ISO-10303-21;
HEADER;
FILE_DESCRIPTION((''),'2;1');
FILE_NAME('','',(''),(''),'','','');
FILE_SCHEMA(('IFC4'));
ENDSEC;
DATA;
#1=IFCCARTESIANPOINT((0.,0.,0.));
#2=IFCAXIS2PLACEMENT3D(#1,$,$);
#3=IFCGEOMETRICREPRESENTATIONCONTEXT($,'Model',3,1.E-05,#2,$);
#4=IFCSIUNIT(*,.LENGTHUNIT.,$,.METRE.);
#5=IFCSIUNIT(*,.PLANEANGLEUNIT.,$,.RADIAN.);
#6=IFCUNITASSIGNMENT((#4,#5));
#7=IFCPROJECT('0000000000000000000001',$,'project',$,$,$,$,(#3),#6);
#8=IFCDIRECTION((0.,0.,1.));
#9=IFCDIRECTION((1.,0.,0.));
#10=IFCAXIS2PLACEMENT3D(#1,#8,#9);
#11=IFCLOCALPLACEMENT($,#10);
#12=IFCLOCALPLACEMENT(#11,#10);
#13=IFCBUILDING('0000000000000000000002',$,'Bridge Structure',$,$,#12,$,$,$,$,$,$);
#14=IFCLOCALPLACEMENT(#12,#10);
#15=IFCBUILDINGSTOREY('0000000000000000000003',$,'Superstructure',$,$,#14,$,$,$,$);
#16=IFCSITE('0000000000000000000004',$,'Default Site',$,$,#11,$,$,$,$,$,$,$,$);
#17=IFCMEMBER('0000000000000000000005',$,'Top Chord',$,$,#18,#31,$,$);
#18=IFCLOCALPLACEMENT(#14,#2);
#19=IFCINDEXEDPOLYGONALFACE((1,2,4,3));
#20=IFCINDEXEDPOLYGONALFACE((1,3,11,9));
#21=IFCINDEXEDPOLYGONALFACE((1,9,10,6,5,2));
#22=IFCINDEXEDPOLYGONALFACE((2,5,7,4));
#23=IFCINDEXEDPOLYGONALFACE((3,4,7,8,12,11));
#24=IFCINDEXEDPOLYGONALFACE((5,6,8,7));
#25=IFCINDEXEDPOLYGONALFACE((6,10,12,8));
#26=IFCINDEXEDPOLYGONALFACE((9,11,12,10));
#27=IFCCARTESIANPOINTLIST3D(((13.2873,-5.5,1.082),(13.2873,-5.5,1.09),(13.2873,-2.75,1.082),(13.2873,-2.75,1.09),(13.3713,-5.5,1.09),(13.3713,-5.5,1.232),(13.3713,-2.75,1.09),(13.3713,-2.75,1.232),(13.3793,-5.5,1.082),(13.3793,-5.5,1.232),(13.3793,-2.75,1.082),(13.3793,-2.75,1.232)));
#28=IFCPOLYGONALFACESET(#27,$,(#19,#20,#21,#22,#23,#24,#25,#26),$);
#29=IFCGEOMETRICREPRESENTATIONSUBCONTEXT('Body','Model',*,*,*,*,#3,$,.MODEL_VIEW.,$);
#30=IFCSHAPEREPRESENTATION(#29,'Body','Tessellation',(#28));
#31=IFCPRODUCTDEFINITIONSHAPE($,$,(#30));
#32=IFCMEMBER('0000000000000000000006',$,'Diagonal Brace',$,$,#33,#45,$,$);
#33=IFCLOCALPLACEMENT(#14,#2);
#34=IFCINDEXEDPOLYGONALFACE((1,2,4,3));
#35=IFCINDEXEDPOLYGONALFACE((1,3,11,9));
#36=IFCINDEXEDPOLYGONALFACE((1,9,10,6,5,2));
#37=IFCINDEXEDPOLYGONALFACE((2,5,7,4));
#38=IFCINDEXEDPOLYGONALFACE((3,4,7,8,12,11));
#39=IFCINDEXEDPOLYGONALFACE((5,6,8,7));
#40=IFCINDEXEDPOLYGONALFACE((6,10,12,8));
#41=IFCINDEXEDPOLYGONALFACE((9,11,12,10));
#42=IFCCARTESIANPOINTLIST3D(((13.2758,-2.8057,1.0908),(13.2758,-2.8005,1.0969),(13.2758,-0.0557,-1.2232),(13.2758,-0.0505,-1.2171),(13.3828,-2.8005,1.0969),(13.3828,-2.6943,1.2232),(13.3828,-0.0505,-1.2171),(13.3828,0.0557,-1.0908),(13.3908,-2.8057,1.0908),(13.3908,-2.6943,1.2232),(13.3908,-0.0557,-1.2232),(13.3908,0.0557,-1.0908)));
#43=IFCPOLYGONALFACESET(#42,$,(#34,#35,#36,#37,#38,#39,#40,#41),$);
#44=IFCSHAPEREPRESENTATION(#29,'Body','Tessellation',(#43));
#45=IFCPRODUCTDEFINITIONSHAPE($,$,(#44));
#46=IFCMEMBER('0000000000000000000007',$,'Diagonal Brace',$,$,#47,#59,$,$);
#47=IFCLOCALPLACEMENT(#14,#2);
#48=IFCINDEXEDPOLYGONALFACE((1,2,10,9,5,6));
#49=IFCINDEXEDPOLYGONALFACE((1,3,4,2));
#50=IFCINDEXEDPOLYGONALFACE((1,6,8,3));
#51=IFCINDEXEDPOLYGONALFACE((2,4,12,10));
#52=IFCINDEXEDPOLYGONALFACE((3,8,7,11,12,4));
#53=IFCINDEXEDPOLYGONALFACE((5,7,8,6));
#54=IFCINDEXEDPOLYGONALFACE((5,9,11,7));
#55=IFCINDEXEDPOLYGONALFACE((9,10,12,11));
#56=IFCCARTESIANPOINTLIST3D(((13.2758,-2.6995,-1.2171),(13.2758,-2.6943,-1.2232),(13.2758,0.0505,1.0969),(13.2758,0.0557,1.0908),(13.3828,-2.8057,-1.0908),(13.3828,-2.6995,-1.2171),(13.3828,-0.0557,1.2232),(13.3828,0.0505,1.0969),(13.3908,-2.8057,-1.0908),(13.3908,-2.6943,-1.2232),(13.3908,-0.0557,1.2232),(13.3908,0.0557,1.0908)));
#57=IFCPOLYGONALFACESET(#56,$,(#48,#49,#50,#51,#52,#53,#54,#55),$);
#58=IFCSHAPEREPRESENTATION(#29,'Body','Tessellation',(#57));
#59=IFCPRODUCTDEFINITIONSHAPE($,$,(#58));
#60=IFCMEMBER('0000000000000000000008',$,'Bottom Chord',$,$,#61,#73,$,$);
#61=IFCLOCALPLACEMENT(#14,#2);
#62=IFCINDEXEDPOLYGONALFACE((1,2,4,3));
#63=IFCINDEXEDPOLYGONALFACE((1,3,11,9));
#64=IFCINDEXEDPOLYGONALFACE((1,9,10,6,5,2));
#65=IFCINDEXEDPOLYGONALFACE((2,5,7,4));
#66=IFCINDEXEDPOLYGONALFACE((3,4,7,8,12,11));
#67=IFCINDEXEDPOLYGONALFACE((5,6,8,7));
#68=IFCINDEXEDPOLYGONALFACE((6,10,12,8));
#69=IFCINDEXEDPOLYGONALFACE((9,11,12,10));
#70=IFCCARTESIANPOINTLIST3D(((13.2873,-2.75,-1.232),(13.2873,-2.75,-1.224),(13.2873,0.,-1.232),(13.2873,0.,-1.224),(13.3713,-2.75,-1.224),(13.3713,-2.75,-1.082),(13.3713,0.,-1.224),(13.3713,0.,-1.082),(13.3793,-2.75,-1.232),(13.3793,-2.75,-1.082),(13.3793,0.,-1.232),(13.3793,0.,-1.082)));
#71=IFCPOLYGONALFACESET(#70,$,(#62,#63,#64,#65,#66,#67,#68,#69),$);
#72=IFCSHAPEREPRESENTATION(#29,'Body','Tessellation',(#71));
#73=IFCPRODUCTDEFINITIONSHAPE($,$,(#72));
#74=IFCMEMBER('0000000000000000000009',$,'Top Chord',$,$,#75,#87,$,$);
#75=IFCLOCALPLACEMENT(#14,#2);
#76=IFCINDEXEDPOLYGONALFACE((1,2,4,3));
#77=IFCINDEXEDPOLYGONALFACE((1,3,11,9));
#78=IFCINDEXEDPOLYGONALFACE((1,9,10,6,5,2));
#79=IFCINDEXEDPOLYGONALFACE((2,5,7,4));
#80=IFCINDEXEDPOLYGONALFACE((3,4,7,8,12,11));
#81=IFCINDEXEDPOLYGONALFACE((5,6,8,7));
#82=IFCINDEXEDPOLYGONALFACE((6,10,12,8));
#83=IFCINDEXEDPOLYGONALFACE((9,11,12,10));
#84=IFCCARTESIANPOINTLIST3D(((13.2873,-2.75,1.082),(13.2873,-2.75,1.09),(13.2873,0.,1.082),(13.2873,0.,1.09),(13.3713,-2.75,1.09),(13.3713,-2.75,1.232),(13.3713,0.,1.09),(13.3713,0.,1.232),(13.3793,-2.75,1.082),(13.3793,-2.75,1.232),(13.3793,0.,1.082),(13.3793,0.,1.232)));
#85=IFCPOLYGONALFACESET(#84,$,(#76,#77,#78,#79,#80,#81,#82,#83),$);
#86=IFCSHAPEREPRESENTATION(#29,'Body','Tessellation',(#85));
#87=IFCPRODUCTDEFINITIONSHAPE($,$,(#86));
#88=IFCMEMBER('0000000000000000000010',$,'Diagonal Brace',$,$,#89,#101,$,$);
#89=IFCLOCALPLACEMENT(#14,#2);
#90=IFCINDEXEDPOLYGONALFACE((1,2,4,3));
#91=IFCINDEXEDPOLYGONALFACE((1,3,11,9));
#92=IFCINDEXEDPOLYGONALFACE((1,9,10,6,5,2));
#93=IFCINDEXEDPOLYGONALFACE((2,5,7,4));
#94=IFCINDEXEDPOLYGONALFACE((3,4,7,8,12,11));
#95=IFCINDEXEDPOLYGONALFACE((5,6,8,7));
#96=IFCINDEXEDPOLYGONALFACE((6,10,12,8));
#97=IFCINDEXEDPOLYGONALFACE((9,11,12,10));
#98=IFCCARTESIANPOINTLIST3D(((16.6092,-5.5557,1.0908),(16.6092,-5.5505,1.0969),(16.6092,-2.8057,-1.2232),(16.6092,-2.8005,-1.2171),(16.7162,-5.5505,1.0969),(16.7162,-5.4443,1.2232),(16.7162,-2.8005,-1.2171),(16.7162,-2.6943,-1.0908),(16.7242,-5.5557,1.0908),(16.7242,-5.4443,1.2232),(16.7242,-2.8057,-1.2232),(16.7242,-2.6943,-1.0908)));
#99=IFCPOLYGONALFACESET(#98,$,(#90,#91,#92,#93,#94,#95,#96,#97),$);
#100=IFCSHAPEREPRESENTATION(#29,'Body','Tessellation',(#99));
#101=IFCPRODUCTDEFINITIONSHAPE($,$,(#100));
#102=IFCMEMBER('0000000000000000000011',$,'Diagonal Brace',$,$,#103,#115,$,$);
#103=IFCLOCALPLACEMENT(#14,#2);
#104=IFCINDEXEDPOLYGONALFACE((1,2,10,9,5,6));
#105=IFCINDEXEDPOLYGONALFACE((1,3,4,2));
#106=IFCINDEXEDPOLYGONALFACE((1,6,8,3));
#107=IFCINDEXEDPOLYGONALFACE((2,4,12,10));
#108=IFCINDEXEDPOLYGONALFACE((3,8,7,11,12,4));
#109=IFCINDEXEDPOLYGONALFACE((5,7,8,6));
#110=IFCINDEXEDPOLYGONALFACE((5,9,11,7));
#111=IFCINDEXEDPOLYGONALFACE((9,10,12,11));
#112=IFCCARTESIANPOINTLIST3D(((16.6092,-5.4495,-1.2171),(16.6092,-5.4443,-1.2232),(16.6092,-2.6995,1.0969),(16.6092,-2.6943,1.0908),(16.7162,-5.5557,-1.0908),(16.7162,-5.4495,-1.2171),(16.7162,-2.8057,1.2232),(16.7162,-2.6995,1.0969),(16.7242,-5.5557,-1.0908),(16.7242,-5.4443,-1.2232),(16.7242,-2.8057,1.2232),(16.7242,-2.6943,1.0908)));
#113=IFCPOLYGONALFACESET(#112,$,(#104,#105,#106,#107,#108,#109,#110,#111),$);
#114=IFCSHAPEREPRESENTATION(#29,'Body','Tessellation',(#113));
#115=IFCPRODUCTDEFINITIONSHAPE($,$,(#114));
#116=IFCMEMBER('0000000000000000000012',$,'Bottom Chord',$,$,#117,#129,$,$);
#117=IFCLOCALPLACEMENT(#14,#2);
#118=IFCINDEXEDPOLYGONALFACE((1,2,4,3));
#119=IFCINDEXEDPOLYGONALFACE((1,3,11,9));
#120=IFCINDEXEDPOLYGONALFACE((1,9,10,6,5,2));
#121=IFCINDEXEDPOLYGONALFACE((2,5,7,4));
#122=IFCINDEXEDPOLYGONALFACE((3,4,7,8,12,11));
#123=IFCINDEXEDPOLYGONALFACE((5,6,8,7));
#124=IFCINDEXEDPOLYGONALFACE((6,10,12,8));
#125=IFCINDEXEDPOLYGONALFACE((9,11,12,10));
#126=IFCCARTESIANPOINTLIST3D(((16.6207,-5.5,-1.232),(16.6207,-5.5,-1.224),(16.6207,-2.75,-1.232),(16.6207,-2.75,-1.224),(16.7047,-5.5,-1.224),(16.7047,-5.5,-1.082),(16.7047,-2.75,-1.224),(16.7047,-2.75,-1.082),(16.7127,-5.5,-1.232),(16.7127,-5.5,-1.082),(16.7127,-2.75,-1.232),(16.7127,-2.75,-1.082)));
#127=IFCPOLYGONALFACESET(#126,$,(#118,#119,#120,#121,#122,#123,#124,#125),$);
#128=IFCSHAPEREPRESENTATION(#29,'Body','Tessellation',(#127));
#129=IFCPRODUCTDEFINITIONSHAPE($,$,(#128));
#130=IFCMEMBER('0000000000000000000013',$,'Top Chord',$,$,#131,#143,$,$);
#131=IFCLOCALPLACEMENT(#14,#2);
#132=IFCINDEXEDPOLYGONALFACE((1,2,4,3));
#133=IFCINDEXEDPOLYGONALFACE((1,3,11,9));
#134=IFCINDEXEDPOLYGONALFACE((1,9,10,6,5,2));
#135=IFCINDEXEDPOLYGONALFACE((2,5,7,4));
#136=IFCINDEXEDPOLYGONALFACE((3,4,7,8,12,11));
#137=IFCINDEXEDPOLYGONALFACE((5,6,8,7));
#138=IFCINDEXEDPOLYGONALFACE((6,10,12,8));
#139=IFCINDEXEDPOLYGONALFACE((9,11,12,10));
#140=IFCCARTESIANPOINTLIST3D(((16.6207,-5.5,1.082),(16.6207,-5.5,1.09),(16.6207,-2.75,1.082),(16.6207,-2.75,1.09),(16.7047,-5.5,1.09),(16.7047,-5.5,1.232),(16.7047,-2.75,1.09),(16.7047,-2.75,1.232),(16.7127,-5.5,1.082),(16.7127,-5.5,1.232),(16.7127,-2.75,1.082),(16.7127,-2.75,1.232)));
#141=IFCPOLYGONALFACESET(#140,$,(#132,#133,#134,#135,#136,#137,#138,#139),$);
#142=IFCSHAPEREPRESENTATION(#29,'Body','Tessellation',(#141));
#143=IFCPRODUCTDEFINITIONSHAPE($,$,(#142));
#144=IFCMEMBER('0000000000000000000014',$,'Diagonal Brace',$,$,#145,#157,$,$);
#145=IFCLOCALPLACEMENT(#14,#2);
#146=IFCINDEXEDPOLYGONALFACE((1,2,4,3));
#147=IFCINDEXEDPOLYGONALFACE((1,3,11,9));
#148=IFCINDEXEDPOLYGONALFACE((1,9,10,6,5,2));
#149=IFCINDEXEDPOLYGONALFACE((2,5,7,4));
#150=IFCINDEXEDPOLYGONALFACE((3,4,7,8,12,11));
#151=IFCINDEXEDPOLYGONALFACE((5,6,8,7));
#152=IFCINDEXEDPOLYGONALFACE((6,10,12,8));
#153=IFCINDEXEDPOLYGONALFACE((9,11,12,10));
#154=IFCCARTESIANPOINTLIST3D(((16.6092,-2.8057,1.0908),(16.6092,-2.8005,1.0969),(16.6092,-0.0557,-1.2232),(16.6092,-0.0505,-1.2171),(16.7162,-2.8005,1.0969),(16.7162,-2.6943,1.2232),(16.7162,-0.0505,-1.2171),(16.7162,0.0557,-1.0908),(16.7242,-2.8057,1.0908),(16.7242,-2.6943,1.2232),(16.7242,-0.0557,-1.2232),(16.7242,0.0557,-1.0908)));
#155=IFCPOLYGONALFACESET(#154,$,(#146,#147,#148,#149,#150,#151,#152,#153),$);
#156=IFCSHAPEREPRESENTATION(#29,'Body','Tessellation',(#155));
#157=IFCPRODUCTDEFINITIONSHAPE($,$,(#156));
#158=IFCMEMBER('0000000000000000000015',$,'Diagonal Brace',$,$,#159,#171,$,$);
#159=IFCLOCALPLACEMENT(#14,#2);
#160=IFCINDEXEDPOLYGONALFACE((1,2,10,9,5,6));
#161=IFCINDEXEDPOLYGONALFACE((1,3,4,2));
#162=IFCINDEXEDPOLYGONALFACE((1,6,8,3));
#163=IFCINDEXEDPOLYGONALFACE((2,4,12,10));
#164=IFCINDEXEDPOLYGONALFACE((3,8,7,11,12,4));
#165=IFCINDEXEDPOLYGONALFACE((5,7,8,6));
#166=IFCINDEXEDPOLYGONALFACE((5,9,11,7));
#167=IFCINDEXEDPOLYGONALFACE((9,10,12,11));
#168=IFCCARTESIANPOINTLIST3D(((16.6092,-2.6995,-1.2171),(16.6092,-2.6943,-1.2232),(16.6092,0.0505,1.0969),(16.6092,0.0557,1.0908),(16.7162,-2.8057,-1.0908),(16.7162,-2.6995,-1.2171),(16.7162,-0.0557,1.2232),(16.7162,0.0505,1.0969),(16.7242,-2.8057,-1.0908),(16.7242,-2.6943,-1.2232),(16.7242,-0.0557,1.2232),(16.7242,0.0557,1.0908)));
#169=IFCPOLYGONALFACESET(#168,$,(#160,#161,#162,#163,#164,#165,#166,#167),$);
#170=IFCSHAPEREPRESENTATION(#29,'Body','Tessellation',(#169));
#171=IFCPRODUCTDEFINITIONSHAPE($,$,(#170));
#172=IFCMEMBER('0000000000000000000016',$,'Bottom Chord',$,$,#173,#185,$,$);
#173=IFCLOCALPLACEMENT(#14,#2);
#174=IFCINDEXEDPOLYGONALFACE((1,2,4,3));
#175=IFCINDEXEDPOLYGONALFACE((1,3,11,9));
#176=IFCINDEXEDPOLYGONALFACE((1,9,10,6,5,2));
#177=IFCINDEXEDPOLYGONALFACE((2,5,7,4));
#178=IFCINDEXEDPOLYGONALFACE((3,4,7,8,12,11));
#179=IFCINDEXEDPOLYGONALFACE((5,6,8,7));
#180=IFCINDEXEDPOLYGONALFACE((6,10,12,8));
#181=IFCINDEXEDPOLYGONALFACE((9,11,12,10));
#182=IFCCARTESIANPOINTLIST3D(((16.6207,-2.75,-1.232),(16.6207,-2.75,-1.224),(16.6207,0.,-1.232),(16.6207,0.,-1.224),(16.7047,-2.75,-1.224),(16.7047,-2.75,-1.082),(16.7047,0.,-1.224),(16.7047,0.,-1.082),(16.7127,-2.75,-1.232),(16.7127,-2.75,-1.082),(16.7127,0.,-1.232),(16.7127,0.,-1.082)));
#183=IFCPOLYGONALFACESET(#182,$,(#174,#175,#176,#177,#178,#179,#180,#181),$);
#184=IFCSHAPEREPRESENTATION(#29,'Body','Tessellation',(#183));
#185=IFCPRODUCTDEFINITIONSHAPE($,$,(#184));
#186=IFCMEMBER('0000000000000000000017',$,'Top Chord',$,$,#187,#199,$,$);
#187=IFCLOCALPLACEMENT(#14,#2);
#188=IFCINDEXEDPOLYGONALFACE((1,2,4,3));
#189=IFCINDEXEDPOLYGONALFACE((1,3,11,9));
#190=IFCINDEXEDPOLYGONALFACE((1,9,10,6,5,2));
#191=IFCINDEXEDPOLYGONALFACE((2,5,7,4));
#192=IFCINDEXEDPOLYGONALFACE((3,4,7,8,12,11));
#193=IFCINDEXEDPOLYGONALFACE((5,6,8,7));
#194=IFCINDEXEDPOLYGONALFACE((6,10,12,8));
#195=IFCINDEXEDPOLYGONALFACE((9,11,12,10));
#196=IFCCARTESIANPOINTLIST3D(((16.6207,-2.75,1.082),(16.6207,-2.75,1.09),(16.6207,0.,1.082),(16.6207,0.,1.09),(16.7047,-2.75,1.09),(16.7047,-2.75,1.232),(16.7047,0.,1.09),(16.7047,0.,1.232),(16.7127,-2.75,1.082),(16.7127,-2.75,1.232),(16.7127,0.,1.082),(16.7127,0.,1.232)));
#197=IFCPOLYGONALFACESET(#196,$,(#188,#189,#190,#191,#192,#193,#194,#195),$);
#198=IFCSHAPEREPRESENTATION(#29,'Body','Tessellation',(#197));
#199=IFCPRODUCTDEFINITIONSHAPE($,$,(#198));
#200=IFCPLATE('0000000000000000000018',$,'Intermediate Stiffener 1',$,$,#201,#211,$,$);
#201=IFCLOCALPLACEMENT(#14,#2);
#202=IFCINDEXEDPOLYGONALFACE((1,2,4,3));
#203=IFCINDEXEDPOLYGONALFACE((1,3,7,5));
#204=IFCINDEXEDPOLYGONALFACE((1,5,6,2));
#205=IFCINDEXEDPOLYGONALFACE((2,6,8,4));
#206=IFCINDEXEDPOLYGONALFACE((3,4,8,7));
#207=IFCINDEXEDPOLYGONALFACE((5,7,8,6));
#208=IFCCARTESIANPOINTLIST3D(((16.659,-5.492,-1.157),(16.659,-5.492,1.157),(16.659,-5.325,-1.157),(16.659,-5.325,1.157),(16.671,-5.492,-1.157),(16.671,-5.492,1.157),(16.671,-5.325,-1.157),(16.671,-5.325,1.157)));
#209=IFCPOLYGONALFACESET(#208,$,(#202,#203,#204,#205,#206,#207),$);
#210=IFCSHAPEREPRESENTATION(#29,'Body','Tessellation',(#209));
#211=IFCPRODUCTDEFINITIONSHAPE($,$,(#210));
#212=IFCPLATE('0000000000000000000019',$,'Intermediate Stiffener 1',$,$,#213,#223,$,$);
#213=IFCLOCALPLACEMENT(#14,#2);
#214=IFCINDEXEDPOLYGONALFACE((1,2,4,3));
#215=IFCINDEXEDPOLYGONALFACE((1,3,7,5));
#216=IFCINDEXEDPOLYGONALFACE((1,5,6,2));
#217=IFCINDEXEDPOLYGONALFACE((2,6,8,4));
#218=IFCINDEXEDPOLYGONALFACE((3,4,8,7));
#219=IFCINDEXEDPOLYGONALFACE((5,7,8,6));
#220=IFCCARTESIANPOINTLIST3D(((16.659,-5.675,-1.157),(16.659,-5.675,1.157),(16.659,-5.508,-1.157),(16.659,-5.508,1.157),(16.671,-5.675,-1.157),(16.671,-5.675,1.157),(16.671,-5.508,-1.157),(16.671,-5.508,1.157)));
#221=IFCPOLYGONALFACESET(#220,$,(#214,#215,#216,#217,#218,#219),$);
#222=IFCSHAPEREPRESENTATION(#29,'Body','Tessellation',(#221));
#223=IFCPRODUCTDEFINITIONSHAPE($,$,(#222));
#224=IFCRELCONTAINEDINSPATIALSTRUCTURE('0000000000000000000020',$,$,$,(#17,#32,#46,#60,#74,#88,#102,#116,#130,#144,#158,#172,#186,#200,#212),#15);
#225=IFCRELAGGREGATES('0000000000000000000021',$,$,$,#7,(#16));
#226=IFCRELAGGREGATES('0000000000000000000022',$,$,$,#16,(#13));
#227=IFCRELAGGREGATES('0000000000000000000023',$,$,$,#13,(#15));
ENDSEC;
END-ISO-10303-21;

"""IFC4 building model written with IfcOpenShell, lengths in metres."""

from ifc_helpers import new_model, si_unit, frame, origin, origin_with_axes, origin_2d_with_axis, place, context, subcontext, project, spatial, rectangle, l_section, extrude, element, save


model = new_model("IFC4")

# Units and contexts
model_context = context("Model", 3, precision=1e-05, world=origin())
body_context = subcontext(model_context, "Body", "Model", "MODEL_VIEW")
ifc_project = project(units=[si_unit("LENGTHUNIT", "METRE"), si_unit("PLANEANGLEUNIT", "RADIAN")], contexts=[model_context])

# Site, building, storey
site_placement = place(None, origin_with_axes())
site = spatial("IfcSite", under=ifc_project, at=site_placement, Name="Default Site")
building_placement = place(site_placement, origin_with_axes())
building = spatial("IfcBuilding", under=site, at=building_placement, Name="Bridge Structure")
storey_placement = place(building_placement, origin_with_axes())
storey = spatial("IfcBuildingStorey", under=building, at=storey_placement, Name="Superstructure")

# Members
member_placement = place(storey_placement, frame((13.3333, -5.5, 1.157), z_axis=(0.0, 1.0, 0.0), x_axis=(-1.0, 0.0, 0.0)))
element("IfcMember", 1, at=member_placement, inside=storey, Name="Top Chord", context=body_context, shape_type="SweptSolid", body=[
    extrude(l_section(Depth=0.15, Width=0.092, Thickness=0.008, at=origin_2d_with_axis()), origin_with_axes(), (0.0, 0.0, 1.0), 2.75),
])
for number, where, z_axis, x_axis, name in (
    (2, (13.3333, -2.75, 1.157), (0.0, 0.765156, -0.643844), (-1.0, 0.0, 0.0), "Diagonal Brace"),
    (3, (13.3333, -2.75, -1.157), (0.0, 0.765156, 0.643844), (-1.0, 0.0, 0.0), "Diagonal Brace"),
):
    element("IfcMember", number, at=place(storey_placement, frame(where, z_axis=z_axis, x_axis=x_axis)), inside=storey, Name=name, context=body_context, shape_type="SweptSolid", body=[
        extrude(l_section(Depth=0.173, Width=0.115, Thickness=0.008, at=origin_2d_with_axis()), origin_with_axes(), (0.0, 0.0, 1.0), 3.594),
    ])
for number, where, z_axis, x_axis, name in (
    (4, (13.3333, -2.75, -1.157), (0.0, 1.0, 0.0), (-1.0, 0.0, 0.0), "Bottom Chord"),
    (5, (13.3333, -2.75, 1.157), (0.0, 1.0, 0.0), (-1.0, 0.0, 0.0), "Top Chord"),
):
    element("IfcMember", number, at=place(storey_placement, frame(where, z_axis=z_axis, x_axis=x_axis)), inside=storey, Name=name, context=body_context, shape_type="SweptSolid", body=[
        extrude(l_section(Depth=0.15, Width=0.092, Thickness=0.008, at=origin_2d_with_axis()), origin_with_axes(), (0.0, 0.0, 1.0), 2.75),
    ])
for number, where, z_axis, x_axis, name in (
    (6, (16.6667, -5.5, 1.157), (0.0, 0.765156, -0.643844), (-1.0, 0.0, 0.0), "Diagonal Brace"),
    (7, (16.6667, -5.5, -1.157), (0.0, 0.765156, 0.643844), (-1.0, 0.0, 0.0), "Diagonal Brace"),
):
    element("IfcMember", number, at=place(storey_placement, frame(where, z_axis=z_axis, x_axis=x_axis)), inside=storey, Name=name, context=body_context, shape_type="SweptSolid", body=[
        extrude(l_section(Depth=0.173, Width=0.115, Thickness=0.008, at=origin_2d_with_axis()), origin_with_axes(), (0.0, 0.0, 1.0), 3.594),
    ])
for number, where, z_axis, x_axis, name in (
    (8, (16.6667, -5.5, -1.157), (0.0, 1.0, 0.0), (-1.0, 0.0, 0.0), "Bottom Chord"),
    (9, (16.6667, -5.5, 1.157), (0.0, 1.0, 0.0), (-1.0, 0.0, 0.0), "Top Chord"),
):
    element("IfcMember", number, at=place(storey_placement, frame(where, z_axis=z_axis, x_axis=x_axis)), inside=storey, Name=name, context=body_context, shape_type="SweptSolid", body=[
        extrude(l_section(Depth=0.15, Width=0.092, Thickness=0.008, at=origin_2d_with_axis()), origin_with_axes(), (0.0, 0.0, 1.0), 2.75),
    ])
for number, where, z_axis, x_axis, name in (
    (10, (16.6667, -2.75, 1.157), (0.0, 0.765156, -0.643844), (-1.0, 0.0, 0.0), "Diagonal Brace"),
    (11, (16.6667, -2.75, -1.157), (0.0, 0.765156, 0.643844), (-1.0, 0.0, 0.0), "Diagonal Brace"),
):
    element("IfcMember", number, at=place(storey_placement, frame(where, z_axis=z_axis, x_axis=x_axis)), inside=storey, Name=name, context=body_context, shape_type="SweptSolid", body=[
        extrude(l_section(Depth=0.173, Width=0.115, Thickness=0.008, at=origin_2d_with_axis()), origin_with_axes(), (0.0, 0.0, 1.0), 3.594),
    ])
for number, where, z_axis, x_axis, name in (
    (12, (16.6667, -2.75, -1.157), (0.0, 1.0, 0.0), (-1.0, 0.0, 0.0), "Bottom Chord"),
    (13, (16.6667, -2.75, 1.157), (0.0, 1.0, 0.0), (-1.0, 0.0, 0.0), "Top Chord"),
):
    element("IfcMember", number, at=place(storey_placement, frame(where, z_axis=z_axis, x_axis=x_axis)), inside=storey, Name=name, context=body_context, shape_type="SweptSolid", body=[
        extrude(l_section(Depth=0.15, Width=0.092, Thickness=0.008, at=origin_2d_with_axis()), origin_with_axes(), (0.0, 0.0, 1.0), 2.75),
    ])

# Plates
for number, where, z_axis, x_axis, name in (
    (14, (16.665, -5.4085, -1.157), (0.0, 0.0, 1.0), (1.0, 0.0, 0.0), "Intermediate Stiffener 1"),
    (15, (16.665, -5.5915, -1.157), (0.0, 0.0, 1.0), (1.0, 0.0, 0.0), "Intermediate Stiffener 1"),
):
    element("IfcPlate", number, at=place(storey_placement, frame(where, z_axis=z_axis, x_axis=x_axis)), inside=storey, Name=name, context=body_context, shape_type="SweptSolid", body=[
        extrude(rectangle(XDim=0.012, YDim=0.167, at=origin_2d_with_axis()), origin_with_axes(), (0.0, 0.0, 1.0), 2.314),
    ])

save(model, "model.ifc")
